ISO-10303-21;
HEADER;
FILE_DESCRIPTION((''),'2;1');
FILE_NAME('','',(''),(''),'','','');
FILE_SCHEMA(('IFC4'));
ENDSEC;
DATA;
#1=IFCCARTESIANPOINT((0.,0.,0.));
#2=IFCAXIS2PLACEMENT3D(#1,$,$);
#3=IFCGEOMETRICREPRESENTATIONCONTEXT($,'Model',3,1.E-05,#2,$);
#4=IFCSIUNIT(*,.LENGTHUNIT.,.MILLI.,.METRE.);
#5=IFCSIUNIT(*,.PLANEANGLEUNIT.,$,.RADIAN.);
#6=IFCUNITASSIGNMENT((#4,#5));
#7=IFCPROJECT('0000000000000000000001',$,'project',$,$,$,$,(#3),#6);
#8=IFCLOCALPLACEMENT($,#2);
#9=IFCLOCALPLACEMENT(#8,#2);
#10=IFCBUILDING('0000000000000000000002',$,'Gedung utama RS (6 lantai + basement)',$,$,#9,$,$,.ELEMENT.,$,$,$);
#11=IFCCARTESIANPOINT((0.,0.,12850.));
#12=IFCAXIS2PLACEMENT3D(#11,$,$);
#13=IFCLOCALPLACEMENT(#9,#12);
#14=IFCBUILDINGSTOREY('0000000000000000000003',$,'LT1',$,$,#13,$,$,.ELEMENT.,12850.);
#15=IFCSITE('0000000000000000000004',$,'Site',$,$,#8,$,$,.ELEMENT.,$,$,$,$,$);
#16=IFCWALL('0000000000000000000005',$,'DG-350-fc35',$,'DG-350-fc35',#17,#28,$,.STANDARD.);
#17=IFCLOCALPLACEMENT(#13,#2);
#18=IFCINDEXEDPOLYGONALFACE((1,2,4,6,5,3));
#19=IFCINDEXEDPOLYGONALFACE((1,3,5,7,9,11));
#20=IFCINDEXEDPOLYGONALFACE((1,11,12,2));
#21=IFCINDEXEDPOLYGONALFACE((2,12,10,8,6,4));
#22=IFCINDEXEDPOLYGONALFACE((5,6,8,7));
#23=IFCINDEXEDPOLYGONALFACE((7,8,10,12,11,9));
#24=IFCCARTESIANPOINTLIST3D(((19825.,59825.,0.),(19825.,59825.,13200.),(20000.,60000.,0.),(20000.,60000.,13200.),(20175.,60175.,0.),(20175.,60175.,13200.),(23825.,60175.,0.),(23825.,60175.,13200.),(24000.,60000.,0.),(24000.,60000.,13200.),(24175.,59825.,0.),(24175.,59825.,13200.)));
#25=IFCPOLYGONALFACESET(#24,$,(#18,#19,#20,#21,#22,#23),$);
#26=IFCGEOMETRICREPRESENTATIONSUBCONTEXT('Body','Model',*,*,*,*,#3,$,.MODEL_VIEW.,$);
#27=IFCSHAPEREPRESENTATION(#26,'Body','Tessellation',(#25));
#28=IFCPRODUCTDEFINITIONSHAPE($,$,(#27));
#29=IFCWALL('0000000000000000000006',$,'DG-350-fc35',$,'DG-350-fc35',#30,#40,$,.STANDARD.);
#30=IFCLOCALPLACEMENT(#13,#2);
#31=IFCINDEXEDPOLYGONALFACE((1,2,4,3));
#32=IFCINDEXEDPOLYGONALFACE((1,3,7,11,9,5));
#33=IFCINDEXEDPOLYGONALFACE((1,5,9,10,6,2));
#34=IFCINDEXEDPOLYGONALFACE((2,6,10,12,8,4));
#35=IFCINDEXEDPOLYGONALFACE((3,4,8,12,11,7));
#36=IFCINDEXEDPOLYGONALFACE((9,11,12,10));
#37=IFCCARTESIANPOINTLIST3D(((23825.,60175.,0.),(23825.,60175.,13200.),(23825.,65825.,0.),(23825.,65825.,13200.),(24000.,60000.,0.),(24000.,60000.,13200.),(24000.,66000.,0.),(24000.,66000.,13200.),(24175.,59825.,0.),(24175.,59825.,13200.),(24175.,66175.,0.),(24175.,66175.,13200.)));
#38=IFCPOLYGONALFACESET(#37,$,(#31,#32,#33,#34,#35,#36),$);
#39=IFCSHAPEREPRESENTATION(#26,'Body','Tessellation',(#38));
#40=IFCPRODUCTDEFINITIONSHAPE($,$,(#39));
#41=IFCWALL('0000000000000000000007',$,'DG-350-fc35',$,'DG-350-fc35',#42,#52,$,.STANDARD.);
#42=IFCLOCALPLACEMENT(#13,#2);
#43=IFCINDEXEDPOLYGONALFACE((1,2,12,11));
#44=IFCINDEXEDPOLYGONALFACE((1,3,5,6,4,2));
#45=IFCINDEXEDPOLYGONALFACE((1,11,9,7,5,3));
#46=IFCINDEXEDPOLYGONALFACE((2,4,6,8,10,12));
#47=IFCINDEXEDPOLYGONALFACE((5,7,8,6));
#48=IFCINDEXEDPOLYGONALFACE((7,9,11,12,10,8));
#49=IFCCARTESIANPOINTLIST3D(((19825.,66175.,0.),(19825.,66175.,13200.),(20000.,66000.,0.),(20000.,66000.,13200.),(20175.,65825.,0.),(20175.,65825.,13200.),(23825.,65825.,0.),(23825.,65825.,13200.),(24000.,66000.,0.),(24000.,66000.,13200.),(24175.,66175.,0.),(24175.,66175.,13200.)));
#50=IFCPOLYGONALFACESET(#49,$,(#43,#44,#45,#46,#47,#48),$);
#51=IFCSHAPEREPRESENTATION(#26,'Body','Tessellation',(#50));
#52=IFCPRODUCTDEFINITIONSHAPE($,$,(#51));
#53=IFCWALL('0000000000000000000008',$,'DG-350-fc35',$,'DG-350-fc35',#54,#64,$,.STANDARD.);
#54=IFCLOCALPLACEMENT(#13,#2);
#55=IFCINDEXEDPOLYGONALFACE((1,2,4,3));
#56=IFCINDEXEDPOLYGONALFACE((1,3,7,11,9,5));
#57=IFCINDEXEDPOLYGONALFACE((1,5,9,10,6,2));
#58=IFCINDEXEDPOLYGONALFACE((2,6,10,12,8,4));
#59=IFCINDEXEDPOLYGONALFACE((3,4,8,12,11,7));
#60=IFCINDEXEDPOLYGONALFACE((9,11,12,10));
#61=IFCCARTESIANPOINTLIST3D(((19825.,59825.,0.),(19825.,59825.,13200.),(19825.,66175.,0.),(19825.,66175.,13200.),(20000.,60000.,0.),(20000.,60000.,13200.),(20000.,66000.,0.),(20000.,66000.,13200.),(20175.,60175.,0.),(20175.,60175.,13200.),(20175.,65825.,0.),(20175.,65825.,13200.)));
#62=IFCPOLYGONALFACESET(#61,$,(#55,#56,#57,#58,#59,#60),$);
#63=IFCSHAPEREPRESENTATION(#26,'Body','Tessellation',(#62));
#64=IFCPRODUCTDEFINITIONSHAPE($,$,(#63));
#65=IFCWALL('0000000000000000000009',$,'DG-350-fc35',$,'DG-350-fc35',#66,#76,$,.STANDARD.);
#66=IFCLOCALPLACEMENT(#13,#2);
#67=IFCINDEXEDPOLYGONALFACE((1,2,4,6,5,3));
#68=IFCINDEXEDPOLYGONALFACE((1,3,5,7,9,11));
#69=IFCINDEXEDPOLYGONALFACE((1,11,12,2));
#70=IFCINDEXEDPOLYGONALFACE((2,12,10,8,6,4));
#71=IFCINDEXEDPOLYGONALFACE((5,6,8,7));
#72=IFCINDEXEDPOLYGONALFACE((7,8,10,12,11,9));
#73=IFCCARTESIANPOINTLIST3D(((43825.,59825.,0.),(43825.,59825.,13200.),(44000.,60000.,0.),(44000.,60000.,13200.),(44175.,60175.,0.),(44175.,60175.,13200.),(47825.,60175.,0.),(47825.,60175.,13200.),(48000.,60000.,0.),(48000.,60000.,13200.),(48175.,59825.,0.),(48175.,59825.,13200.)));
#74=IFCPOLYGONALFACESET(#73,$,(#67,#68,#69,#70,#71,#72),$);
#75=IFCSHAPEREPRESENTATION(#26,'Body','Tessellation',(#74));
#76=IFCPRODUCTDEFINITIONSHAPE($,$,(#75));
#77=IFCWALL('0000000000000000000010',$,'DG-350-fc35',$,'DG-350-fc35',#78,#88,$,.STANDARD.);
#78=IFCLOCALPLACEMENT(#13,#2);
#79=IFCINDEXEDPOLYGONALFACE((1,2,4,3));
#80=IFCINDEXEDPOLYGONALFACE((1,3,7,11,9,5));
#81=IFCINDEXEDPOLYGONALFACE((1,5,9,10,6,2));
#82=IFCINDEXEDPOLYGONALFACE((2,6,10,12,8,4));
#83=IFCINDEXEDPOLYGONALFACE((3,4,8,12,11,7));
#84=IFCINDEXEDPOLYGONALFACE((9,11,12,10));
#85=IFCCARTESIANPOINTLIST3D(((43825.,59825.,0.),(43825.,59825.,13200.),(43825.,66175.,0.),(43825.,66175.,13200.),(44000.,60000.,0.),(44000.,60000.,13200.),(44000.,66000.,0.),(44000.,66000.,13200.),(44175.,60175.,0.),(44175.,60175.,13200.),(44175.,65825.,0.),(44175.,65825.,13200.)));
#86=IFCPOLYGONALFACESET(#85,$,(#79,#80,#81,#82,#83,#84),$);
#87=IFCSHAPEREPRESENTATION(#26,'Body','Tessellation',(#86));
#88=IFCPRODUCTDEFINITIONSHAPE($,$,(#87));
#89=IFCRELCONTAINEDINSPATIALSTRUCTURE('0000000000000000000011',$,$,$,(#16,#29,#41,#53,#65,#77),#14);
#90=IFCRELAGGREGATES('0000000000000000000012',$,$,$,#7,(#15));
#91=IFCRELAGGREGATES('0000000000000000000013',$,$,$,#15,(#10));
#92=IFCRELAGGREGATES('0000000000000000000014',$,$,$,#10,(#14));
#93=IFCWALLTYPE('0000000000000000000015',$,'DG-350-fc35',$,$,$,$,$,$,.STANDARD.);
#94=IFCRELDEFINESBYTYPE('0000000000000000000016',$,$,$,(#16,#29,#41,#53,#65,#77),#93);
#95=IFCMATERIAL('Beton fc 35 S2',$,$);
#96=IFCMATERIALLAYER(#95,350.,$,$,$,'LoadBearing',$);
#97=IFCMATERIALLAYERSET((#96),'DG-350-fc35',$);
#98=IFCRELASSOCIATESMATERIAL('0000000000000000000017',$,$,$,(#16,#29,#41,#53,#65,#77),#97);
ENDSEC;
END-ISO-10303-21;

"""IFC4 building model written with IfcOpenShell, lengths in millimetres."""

from ifc_helpers import new_model, si_unit, frame, origin, place, context, subcontext, project, spatial, polyline, outline, extrude, material, layer, layer_set, layer_usage, type_object, element, save


model = new_model("IFC4")

# Units and contexts
model_context = context("Model", 3, precision=1e-05, world=origin())
body_context = subcontext(model_context, "Body", "Model", "MODEL_VIEW")
ifc_project = project(units=[si_unit("LENGTHUNIT", "METRE", prefix="MILLI"), si_unit("PLANEANGLEUNIT", "RADIAN")], contexts=[model_context])

# Site, building, storey
site_placement = place(None, origin())
site = spatial("IfcSite", under=ifc_project, at=site_placement, Name="Site", CompositionType="ELEMENT")
building_placement = place(site_placement, origin())
building = spatial("IfcBuilding", under=site, at=building_placement, Name="Gedung utama RS (6 lantai + basement)", CompositionType="ELEMENT")
storey_placement = place(building_placement, frame((0.0, 0.0, 12850.0)))
storey = spatial("IfcBuildingStorey", under=building, at=storey_placement, Name="LT1", CompositionType="ELEMENT", Elevation=12850.0)

# Walls
ifc_material = material(Name="Beton fc 35 S2")
ifc_layer = layer(ifc_material, 350.0, Category="LoadBearing")
ifc_layer_set = layer_set([ifc_layer], Name="DG-350-fc35")
ifc_layer_usage = layer_usage(ifc_layer_set, "AXIS2", "NEGATIVE", 175.0)
wall_type = type_object("IfcWallType", Name="DG-350-fc35", PredefinedType="STANDARD")
wall_1_placement = place(storey_placement, frame((20000.0, 60000.0, 0.0), z_axis=(0.0, 0.0, 1.0), x_axis=(1.0, 0.0, 0.0)))
element("IfcWall", 1, at=wall_1_placement, inside=storey, type_object=wall_type, material=ifc_layer_usage, Name="DG-350-fc35", ObjectType="DG-350-fc35", PredefinedType="STANDARD", context=body_context, shape_type="SweptSolid", body=[
    extrude(outline(polyline([(-175.0, -175.0), (0.0, 0.0), (175.0, 175.0), (3825.0, 175.0), (4000.0, 0.0), (4175.0, -175.0), (-175.0, -175.0)])), origin(), (0.0, 0.0, 1.0), 13200.0),
])
wall_2_placement = place(storey_placement, frame((24000.0, 60000.0, 0.0), z_axis=(0.0, 0.0, 1.0), x_axis=(0.0, 1.0, 0.0)))
element("IfcWall", 2, at=wall_2_placement, inside=storey, type_object=wall_type, material=ifc_layer_usage, Name="DG-350-fc35", ObjectType="DG-350-fc35", PredefinedType="STANDARD", context=body_context, shape_type="SweptSolid", body=[
    extrude(outline(polyline([(-175.0, -175.0), (0.0, 0.0), (175.0, 175.0), (5825.0, 175.0), (6000.0, 0.0), (6175.0, -175.0), (-175.0, -175.0)])), origin(), (0.0, 0.0, 1.0), 13200.0),
])
wall_3_placement = place(storey_placement, frame((24000.0, 66000.0, 0.0), z_axis=(0.0, 0.0, 1.0), x_axis=(-1.0, 0.0, 0.0)))
element("IfcWall", 3, at=wall_3_placement, inside=storey, type_object=wall_type, material=ifc_layer_usage, Name="DG-350-fc35", ObjectType="DG-350-fc35", PredefinedType="STANDARD", context=body_context, shape_type="SweptSolid", body=[
    extrude(outline(polyline([(-175.0, -175.0), (0.0, 0.0), (175.0, 175.0), (3825.0, 175.0), (4000.0, 0.0), (4175.0, -175.0), (-175.0, -175.0)])), origin(), (0.0, 0.0, 1.0), 13200.0),
])
wall_4_placement = place(storey_placement, frame((20000.0, 66000.0, 0.0), z_axis=(0.0, 0.0, 1.0), x_axis=(0.0, -1.0, 0.0)))
element("IfcWall", 4, at=wall_4_placement, inside=storey, type_object=wall_type, material=ifc_layer_usage, Name="DG-350-fc35", ObjectType="DG-350-fc35", PredefinedType="STANDARD", context=body_context, shape_type="SweptSolid", body=[
    extrude(outline(polyline([(-175.0, -175.0), (0.0, 0.0), (175.0, 175.0), (5825.0, 175.0), (6000.0, 0.0), (6175.0, -175.0), (-175.0, -175.0)])), origin(), (0.0, 0.0, 1.0), 13200.0),
])
wall_5_placement = place(storey_placement, frame((44000.0, 60000.0, 0.0), z_axis=(0.0, 0.0, 1.0), x_axis=(1.0, 0.0, 0.0)))
element("IfcWall", 5, at=wall_5_placement, inside=storey, type_object=wall_type, material=ifc_layer_usage, Name="DG-350-fc35", ObjectType="DG-350-fc35", PredefinedType="STANDARD", context=body_context, shape_type="SweptSolid", body=[
    extrude(outline(polyline([(-175.0, -175.0), (0.0, 0.0), (175.0, 175.0), (3825.0, 175.0), (4000.0, 0.0), (4175.0, -175.0), (-175.0, -175.0)])), origin(), (0.0, 0.0, 1.0), 13200.0),
])
wall_6_placement = place(storey_placement, frame((44000.0, 66000.0, 0.0), z_axis=(0.0, 0.0, 1.0), x_axis=(0.0, -1.0, 0.0)))
element("IfcWall", 6, at=wall_6_placement, inside=storey, type_object=wall_type, material=ifc_layer_usage, Name="DG-350-fc35", ObjectType="DG-350-fc35", PredefinedType="STANDARD", context=body_context, shape_type="SweptSolid", body=[
    extrude(outline(polyline([(-175.0, -175.0), (0.0, 0.0), (175.0, 175.0), (5825.0, 175.0), (6000.0, 0.0), (6175.0, -175.0), (-175.0, -175.0)])), origin(), (0.0, 0.0, 1.0), 13200.0),
])

save(model, "model.ifc")
